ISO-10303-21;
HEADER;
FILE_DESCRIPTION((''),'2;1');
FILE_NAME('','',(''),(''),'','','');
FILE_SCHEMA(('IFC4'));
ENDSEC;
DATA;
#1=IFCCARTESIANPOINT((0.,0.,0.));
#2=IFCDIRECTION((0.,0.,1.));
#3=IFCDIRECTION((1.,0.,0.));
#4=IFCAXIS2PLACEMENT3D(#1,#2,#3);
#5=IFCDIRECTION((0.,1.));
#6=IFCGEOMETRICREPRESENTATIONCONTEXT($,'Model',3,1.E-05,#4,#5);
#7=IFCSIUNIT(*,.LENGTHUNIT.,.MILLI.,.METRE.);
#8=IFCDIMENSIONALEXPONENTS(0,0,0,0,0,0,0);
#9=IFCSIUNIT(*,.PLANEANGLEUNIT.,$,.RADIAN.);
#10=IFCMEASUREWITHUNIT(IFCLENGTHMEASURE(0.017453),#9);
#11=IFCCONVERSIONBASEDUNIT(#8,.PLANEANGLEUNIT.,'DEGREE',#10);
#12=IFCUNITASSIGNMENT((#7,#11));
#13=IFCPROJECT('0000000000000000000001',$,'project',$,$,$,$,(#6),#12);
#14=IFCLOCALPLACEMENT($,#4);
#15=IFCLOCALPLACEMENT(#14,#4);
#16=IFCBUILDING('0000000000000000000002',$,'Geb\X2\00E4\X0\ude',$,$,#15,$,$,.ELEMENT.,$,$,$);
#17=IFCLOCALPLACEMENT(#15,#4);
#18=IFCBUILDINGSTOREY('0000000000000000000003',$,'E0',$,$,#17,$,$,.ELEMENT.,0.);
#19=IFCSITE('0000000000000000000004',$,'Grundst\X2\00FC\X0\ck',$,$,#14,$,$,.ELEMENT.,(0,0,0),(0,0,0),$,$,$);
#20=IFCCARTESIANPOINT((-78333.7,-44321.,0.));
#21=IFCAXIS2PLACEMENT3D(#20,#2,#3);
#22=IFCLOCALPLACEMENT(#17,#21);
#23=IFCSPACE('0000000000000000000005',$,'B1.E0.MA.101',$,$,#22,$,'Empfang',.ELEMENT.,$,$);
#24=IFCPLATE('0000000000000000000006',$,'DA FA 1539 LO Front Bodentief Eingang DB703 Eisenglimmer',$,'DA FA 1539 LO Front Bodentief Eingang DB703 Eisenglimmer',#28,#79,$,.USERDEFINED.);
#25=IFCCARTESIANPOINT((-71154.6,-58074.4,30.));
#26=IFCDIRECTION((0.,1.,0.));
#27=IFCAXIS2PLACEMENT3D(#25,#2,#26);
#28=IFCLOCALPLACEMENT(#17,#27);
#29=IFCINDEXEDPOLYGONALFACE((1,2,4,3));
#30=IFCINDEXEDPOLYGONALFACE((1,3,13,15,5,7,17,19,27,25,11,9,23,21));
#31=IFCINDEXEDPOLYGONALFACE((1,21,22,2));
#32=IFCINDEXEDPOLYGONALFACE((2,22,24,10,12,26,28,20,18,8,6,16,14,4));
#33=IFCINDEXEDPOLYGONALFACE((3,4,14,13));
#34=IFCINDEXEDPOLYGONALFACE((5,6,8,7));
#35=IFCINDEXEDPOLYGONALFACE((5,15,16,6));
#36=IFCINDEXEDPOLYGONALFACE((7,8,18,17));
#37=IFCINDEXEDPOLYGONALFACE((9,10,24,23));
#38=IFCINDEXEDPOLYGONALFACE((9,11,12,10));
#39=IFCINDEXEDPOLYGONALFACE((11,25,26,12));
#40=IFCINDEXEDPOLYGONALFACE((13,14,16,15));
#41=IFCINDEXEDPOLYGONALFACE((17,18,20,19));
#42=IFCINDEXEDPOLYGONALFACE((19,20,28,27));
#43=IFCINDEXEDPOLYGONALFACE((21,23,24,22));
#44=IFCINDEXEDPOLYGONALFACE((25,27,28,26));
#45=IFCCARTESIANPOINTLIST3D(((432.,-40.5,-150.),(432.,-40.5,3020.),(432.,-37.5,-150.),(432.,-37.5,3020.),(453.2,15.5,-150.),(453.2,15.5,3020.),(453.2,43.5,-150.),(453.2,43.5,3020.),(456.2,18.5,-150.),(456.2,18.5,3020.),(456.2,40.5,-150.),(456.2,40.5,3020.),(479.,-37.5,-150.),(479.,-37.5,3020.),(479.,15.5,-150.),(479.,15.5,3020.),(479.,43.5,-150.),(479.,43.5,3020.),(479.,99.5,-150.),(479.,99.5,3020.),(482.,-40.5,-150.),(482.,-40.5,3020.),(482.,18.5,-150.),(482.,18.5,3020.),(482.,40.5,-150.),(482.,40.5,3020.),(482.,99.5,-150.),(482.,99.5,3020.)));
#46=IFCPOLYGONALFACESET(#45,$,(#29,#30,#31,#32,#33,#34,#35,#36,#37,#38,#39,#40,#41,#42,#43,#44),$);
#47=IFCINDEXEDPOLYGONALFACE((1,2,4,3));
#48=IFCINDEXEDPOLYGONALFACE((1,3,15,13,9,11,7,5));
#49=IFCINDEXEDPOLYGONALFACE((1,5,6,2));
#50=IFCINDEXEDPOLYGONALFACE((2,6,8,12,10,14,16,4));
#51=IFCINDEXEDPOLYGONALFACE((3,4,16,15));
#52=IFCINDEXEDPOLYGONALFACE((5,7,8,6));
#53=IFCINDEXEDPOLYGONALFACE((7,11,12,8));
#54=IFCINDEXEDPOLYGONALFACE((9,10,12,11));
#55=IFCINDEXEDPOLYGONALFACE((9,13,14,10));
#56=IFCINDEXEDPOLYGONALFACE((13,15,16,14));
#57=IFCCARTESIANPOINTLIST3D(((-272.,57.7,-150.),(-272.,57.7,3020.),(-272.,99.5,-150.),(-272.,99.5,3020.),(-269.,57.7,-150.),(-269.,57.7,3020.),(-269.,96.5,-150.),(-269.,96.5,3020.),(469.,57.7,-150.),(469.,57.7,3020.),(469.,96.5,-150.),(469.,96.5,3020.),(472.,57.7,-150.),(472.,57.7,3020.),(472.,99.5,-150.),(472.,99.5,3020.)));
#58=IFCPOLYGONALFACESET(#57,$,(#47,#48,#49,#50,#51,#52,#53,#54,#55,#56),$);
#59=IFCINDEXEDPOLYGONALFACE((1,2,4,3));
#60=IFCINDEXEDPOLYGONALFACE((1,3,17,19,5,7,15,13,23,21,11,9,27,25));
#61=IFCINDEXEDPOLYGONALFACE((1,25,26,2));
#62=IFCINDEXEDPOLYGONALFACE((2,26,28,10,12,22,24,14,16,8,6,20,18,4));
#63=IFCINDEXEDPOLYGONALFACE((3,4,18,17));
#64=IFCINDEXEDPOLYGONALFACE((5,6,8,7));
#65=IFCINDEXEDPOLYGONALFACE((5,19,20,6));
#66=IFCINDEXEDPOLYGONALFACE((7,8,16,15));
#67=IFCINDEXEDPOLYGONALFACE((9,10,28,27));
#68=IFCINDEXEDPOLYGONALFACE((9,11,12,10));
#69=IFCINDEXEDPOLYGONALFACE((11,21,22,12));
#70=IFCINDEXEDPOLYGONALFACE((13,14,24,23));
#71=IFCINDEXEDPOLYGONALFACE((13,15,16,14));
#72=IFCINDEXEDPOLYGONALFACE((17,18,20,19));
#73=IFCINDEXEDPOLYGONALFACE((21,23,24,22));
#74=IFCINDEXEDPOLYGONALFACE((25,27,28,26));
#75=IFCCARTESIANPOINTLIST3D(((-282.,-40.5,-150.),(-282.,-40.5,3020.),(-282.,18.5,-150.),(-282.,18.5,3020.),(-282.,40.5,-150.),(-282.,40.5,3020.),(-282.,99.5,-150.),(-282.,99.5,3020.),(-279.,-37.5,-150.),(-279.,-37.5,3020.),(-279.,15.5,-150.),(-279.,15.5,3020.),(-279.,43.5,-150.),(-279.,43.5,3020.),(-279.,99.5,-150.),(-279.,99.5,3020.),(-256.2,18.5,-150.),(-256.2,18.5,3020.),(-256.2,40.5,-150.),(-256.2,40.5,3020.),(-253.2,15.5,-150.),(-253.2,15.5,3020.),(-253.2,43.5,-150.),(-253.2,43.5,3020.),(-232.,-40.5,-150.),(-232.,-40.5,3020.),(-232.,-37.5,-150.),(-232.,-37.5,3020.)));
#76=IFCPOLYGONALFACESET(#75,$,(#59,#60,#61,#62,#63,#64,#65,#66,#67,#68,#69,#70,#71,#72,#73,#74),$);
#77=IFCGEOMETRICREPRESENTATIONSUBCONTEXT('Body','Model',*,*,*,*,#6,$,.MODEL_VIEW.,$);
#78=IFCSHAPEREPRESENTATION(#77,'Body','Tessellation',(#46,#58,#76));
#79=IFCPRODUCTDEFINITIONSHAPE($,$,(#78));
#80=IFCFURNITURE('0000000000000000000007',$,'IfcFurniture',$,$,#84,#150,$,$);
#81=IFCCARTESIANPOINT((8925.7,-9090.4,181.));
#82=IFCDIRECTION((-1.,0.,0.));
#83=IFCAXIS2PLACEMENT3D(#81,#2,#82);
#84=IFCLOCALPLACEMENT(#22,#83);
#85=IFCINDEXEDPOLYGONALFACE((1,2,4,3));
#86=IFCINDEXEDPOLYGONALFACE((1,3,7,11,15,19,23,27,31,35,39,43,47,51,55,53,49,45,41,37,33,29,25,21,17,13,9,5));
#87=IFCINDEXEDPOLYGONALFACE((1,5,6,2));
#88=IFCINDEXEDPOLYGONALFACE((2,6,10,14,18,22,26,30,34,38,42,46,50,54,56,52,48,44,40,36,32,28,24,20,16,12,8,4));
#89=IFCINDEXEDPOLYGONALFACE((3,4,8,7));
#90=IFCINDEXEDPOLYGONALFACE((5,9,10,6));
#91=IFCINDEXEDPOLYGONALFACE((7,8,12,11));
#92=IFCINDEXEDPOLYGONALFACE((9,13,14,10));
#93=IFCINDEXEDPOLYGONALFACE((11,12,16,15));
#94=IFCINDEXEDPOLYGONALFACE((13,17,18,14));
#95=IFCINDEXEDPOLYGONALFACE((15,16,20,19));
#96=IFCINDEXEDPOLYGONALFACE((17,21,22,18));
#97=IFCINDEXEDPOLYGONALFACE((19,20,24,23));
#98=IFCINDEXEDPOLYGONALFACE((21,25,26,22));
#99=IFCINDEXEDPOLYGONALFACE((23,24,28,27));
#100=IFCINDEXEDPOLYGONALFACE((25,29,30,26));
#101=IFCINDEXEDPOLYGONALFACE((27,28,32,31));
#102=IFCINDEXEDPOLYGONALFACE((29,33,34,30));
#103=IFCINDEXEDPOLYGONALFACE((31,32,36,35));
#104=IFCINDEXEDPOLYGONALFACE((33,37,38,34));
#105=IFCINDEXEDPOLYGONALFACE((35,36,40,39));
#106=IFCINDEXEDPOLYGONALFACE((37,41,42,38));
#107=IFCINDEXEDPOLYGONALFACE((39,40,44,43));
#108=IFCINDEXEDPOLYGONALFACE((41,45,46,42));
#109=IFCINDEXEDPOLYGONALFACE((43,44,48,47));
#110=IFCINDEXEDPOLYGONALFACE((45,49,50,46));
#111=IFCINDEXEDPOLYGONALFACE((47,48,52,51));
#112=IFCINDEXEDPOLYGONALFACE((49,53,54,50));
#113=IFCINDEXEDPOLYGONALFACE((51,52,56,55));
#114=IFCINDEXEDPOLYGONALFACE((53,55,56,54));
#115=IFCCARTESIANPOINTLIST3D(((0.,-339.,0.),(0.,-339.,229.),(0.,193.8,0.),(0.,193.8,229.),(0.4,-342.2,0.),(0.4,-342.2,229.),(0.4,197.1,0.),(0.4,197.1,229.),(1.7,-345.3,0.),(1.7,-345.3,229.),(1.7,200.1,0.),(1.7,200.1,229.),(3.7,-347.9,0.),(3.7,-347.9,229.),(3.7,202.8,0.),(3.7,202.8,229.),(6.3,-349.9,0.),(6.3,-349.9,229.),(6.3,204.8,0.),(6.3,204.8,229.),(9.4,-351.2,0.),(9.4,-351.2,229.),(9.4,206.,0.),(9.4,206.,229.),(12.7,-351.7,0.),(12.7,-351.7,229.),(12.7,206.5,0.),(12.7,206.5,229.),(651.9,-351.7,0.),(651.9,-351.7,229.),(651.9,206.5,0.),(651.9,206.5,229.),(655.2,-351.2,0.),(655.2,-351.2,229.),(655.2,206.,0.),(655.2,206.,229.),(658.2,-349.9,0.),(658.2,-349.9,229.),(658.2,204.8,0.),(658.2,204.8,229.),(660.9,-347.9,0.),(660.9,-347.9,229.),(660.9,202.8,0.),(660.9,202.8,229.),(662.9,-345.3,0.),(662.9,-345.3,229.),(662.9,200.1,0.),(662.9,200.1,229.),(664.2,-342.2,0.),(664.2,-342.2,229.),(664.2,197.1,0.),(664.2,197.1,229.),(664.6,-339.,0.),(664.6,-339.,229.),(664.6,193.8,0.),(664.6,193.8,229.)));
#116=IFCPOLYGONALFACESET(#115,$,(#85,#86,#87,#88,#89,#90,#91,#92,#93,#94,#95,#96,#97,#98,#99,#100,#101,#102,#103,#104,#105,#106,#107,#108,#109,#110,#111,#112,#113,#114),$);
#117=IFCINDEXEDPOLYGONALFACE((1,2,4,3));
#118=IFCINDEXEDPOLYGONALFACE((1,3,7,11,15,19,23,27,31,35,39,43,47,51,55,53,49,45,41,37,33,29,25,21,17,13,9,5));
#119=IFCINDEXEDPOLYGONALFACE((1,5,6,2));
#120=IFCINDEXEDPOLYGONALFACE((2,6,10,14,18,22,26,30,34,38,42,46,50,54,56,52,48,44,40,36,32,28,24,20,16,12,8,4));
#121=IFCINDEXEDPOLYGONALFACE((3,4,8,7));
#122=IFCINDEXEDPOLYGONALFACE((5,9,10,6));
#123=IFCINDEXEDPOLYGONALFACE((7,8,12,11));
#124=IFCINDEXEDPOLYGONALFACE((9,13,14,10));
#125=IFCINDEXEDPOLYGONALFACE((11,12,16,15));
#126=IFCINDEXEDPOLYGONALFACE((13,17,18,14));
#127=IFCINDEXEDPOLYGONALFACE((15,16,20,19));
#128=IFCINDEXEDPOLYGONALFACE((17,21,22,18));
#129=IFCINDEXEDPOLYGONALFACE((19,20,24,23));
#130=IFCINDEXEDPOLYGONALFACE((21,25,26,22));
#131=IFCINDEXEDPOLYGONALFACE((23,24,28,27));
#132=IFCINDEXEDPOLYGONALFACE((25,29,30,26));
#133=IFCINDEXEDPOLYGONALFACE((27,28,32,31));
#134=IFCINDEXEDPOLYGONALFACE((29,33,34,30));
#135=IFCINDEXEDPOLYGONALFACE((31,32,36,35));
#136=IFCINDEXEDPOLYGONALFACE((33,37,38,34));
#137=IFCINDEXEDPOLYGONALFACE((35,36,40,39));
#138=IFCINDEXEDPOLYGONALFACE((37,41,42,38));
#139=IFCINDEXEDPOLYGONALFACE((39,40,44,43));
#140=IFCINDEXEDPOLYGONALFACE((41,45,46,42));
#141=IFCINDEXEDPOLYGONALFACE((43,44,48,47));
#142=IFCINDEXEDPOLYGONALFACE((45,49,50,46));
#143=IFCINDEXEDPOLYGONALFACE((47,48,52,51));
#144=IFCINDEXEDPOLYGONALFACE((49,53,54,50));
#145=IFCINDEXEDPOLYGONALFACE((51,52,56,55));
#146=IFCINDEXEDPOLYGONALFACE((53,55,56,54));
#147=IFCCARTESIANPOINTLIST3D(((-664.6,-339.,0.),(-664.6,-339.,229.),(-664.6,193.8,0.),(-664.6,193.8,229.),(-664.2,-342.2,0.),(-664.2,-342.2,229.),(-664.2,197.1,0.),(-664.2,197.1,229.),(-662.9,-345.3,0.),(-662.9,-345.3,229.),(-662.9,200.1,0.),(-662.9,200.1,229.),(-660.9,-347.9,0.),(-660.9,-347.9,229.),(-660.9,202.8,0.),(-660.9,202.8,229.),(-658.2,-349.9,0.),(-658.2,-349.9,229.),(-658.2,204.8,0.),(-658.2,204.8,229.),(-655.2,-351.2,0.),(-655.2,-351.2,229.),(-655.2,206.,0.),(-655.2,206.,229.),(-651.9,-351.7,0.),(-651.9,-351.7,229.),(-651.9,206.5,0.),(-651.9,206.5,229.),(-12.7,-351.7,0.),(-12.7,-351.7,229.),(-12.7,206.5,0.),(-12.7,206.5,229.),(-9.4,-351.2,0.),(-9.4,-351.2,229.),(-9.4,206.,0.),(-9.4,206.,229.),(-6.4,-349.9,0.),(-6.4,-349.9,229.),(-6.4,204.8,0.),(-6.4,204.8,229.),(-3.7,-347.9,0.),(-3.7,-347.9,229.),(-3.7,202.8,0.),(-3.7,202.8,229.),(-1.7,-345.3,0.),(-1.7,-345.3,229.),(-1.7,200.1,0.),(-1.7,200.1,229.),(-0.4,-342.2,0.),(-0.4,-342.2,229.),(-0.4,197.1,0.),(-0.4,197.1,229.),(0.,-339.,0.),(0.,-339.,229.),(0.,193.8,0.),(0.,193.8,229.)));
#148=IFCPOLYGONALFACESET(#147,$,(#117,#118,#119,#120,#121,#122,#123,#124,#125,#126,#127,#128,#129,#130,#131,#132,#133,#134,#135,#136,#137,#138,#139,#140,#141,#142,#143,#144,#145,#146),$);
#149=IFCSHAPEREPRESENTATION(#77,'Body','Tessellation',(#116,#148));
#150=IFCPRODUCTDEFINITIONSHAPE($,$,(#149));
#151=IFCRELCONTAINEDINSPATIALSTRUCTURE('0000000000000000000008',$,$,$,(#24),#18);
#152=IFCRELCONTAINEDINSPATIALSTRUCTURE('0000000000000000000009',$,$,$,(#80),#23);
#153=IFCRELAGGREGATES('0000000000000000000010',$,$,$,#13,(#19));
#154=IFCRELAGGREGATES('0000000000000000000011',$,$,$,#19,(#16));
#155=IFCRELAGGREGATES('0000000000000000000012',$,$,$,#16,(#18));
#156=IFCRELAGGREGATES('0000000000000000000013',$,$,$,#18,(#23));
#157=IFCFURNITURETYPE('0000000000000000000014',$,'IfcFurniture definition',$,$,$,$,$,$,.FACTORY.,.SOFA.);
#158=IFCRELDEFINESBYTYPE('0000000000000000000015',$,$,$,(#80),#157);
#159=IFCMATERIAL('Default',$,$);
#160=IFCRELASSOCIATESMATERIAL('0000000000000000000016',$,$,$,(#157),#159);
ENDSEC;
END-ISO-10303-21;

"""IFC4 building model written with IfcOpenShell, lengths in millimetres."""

from ifc_helpers import new_model, entity, si_unit, converted_unit, direction, frame, origin_with_axes, place, context, subcontext, project, spatial, line, arc, indexed_curve, outline, extrude, material, type_object, element, save


model = new_model("IFC4")

# Units and contexts
model_context = context("Model", 3, precision=1e-05, world=origin_with_axes(), true_north=direction((0.0, 1.0)))
body_context = subcontext(model_context, "Body", "Model", "MODEL_VIEW")
ifc_project = project(units=[si_unit("LENGTHUNIT", "METRE", prefix="MILLI"), converted_unit("PLANEANGLEUNIT", "DEGREE", entity("IfcLengthMeasure", 0.017453), si_unit("PLANEANGLEUNIT", "RADIAN"), dimensions=[0, 0, 0, 0, 0, 0, 0])], contexts=[model_context])

# Site, building, storey
site_placement = place(None, origin_with_axes())
site = spatial("IfcSite", under=ifc_project, at=site_placement, Name="Grundstück", CompositionType="ELEMENT", RefLatitude=(0, 0, 0), RefLongitude=(0, 0, 0))
building_placement = place(site_placement, origin_with_axes())
building = spatial("IfcBuilding", under=site, at=building_placement, Name="Gebäude", CompositionType="ELEMENT")
storey_placement = place(building_placement, origin_with_axes())
storey = spatial("IfcBuildingStorey", under=building, at=storey_placement, Name="E0", CompositionType="ELEMENT", Elevation=0.0)

# Plate
plate_1_placement = place(storey_placement, frame((-71154.6, -58074.4, 30.0), z_axis=(0.0, 0.0, 1.0), x_axis=(0.0, 1.0, 0.0)))
element("IfcPlate", 1, at=plate_1_placement, inside=storey, Name="DA FA 1539 LO Front Bodentief Eingang DB703 Eisenglimmer", ObjectType="DA FA 1539 LO Front Bodentief Eingang DB703 Eisenglimmer", PredefinedType="USERDEFINED", context=body_context, shape_type="SweptSolid", body=[
    extrude(outline(indexed_curve([(482.0, 99.5), (482.0, 40.5), (456.2, 40.5), (456.2, 18.5), (482.0, 18.5), (482.0, -40.5), (432.0, -40.5), (432.0, -37.5), (479.0, -37.5), (479.0, 15.5), (453.2, 15.5), (453.2, 43.5), (479.0, 43.5), (479.0, 99.5)], segments=[line(1, 2), line(2, 3), line(3, 4), line(4, 5), line(5, 6), line(6, 7), line(7, 8), line(8, 9), line(9, 10), line(10, 11), line(11, 12), line(12, 13), line(13, 14), line(14, 1)])), frame((0.0, 0.0, -150.0), z_axis=(0.0, 0.0, 1.0), x_axis=(1.0, 0.0, 0.0)), (0.0, 0.0, 1.0), 3170.0),
    extrude(outline(indexed_curve([(472.0, 99.5), (472.0, 57.7), (469.0, 57.7), (469.0, 96.5), (-269.0, 96.5), (-269.0, 57.7), (-272.0, 57.7), (-272.0, 99.5)], segments=[line(1, 2), line(2, 3), line(3, 4), line(4, 5), line(5, 6), line(6, 7), line(7, 8), line(8, 1)])), frame((0.0, 0.0, -150.0), z_axis=(0.0, 0.0, 1.0), x_axis=(1.0, 0.0, 0.0)), (0.0, 0.0, 1.0), 3170.0),
    extrude(outline(indexed_curve([(-282.0, 99.5), (-282.0, 40.5), (-256.2, 40.5), (-256.2, 18.5), (-282.0, 18.5), (-282.0, -40.5), (-232.0, -40.5), (-232.0, -37.5), (-279.0, -37.5), (-279.0, 15.5), (-253.2, 15.5), (-253.2, 43.5), (-279.0, 43.5), (-279.0, 99.5)], segments=[line(1, 2), line(2, 3), line(3, 4), line(4, 5), line(5, 6), line(6, 7), line(7, 8), line(8, 9), line(9, 10), line(10, 11), line(11, 12), line(12, 13), line(13, 14), line(14, 1)])), frame((0.0, 0.0, -150.0), z_axis=(0.0, 0.0, 1.0), x_axis=(1.0, 0.0, 0.0)), (0.0, 0.0, 1.0), 3170.0),
])

# Shared definitions
space_1_placement = place(storey_placement, frame((-78333.7, -44321.0, 0.0), z_axis=(0.0, 0.0, 1.0), x_axis=(1.0, 0.0, 0.0)))
space_1 = spatial("IfcSpace", under=storey, at=space_1_placement, Name="B1.E0.MA.101", LongName="Empfang", CompositionType="ELEMENT")

# Furniture
ifc_material_1 = material(Name="Default")
furniture_type_1 = type_object("IfcFurnitureType", Name="IfcFurniture definition", AssemblyPlace="FACTORY", PredefinedType="SOFA", material=ifc_material_1)
furniture_1_placement = place(space_1_placement, frame((8925.7, -9090.4, 181.0), z_axis=(0.0, 0.0, 1.0), x_axis=(-1.0, 0.0, 0.0)))
element("IfcFurniture", 2, at=furniture_1_placement, inside=space_1, type_object=furniture_type_1, Name="IfcFurniture", context=body_context, shape_type="SweptSolid", body=[
    extrude(outline(indexed_curve([(651.9, 206.5), (660.9, 202.8), (664.6, 193.8), (664.6, -339.0), (660.9, -347.9), (651.9, -351.7), (12.7, -351.7), (3.7, -347.9), (0.0, -339.0), (0.0, 193.8), (3.7, 202.8), (12.7, 206.5)], segments=[arc(1, 2, 3), line(3, 4), arc(4, 5, 6), line(6, 7), arc(7, 8, 9), line(9, 10), arc(10, 11, 12), line(12, 1)])), origin_with_axes(), (0.0, 0.0, 1.0), 229.0),
    extrude(outline(indexed_curve([(-651.9, 206.5), (-660.9, 202.8), (-664.6, 193.8), (-664.6, -339.0), (-660.9, -347.9), (-651.9, -351.7), (-12.7, -351.7), (-3.7, -347.9), (0.0, -339.0), (0.0, 193.8), (-3.7, 202.8), (-12.7, 206.5)], segments=[arc(1, 2, 3), line(3, 4), arc(4, 5, 6), line(6, 7), arc(7, 8, 9), line(9, 10), arc(10, 11, 12), line(12, 1)])), origin_with_axes(), (0.0, 0.0, 1.0), 229.0),
])

save(model, "model.ifc")
